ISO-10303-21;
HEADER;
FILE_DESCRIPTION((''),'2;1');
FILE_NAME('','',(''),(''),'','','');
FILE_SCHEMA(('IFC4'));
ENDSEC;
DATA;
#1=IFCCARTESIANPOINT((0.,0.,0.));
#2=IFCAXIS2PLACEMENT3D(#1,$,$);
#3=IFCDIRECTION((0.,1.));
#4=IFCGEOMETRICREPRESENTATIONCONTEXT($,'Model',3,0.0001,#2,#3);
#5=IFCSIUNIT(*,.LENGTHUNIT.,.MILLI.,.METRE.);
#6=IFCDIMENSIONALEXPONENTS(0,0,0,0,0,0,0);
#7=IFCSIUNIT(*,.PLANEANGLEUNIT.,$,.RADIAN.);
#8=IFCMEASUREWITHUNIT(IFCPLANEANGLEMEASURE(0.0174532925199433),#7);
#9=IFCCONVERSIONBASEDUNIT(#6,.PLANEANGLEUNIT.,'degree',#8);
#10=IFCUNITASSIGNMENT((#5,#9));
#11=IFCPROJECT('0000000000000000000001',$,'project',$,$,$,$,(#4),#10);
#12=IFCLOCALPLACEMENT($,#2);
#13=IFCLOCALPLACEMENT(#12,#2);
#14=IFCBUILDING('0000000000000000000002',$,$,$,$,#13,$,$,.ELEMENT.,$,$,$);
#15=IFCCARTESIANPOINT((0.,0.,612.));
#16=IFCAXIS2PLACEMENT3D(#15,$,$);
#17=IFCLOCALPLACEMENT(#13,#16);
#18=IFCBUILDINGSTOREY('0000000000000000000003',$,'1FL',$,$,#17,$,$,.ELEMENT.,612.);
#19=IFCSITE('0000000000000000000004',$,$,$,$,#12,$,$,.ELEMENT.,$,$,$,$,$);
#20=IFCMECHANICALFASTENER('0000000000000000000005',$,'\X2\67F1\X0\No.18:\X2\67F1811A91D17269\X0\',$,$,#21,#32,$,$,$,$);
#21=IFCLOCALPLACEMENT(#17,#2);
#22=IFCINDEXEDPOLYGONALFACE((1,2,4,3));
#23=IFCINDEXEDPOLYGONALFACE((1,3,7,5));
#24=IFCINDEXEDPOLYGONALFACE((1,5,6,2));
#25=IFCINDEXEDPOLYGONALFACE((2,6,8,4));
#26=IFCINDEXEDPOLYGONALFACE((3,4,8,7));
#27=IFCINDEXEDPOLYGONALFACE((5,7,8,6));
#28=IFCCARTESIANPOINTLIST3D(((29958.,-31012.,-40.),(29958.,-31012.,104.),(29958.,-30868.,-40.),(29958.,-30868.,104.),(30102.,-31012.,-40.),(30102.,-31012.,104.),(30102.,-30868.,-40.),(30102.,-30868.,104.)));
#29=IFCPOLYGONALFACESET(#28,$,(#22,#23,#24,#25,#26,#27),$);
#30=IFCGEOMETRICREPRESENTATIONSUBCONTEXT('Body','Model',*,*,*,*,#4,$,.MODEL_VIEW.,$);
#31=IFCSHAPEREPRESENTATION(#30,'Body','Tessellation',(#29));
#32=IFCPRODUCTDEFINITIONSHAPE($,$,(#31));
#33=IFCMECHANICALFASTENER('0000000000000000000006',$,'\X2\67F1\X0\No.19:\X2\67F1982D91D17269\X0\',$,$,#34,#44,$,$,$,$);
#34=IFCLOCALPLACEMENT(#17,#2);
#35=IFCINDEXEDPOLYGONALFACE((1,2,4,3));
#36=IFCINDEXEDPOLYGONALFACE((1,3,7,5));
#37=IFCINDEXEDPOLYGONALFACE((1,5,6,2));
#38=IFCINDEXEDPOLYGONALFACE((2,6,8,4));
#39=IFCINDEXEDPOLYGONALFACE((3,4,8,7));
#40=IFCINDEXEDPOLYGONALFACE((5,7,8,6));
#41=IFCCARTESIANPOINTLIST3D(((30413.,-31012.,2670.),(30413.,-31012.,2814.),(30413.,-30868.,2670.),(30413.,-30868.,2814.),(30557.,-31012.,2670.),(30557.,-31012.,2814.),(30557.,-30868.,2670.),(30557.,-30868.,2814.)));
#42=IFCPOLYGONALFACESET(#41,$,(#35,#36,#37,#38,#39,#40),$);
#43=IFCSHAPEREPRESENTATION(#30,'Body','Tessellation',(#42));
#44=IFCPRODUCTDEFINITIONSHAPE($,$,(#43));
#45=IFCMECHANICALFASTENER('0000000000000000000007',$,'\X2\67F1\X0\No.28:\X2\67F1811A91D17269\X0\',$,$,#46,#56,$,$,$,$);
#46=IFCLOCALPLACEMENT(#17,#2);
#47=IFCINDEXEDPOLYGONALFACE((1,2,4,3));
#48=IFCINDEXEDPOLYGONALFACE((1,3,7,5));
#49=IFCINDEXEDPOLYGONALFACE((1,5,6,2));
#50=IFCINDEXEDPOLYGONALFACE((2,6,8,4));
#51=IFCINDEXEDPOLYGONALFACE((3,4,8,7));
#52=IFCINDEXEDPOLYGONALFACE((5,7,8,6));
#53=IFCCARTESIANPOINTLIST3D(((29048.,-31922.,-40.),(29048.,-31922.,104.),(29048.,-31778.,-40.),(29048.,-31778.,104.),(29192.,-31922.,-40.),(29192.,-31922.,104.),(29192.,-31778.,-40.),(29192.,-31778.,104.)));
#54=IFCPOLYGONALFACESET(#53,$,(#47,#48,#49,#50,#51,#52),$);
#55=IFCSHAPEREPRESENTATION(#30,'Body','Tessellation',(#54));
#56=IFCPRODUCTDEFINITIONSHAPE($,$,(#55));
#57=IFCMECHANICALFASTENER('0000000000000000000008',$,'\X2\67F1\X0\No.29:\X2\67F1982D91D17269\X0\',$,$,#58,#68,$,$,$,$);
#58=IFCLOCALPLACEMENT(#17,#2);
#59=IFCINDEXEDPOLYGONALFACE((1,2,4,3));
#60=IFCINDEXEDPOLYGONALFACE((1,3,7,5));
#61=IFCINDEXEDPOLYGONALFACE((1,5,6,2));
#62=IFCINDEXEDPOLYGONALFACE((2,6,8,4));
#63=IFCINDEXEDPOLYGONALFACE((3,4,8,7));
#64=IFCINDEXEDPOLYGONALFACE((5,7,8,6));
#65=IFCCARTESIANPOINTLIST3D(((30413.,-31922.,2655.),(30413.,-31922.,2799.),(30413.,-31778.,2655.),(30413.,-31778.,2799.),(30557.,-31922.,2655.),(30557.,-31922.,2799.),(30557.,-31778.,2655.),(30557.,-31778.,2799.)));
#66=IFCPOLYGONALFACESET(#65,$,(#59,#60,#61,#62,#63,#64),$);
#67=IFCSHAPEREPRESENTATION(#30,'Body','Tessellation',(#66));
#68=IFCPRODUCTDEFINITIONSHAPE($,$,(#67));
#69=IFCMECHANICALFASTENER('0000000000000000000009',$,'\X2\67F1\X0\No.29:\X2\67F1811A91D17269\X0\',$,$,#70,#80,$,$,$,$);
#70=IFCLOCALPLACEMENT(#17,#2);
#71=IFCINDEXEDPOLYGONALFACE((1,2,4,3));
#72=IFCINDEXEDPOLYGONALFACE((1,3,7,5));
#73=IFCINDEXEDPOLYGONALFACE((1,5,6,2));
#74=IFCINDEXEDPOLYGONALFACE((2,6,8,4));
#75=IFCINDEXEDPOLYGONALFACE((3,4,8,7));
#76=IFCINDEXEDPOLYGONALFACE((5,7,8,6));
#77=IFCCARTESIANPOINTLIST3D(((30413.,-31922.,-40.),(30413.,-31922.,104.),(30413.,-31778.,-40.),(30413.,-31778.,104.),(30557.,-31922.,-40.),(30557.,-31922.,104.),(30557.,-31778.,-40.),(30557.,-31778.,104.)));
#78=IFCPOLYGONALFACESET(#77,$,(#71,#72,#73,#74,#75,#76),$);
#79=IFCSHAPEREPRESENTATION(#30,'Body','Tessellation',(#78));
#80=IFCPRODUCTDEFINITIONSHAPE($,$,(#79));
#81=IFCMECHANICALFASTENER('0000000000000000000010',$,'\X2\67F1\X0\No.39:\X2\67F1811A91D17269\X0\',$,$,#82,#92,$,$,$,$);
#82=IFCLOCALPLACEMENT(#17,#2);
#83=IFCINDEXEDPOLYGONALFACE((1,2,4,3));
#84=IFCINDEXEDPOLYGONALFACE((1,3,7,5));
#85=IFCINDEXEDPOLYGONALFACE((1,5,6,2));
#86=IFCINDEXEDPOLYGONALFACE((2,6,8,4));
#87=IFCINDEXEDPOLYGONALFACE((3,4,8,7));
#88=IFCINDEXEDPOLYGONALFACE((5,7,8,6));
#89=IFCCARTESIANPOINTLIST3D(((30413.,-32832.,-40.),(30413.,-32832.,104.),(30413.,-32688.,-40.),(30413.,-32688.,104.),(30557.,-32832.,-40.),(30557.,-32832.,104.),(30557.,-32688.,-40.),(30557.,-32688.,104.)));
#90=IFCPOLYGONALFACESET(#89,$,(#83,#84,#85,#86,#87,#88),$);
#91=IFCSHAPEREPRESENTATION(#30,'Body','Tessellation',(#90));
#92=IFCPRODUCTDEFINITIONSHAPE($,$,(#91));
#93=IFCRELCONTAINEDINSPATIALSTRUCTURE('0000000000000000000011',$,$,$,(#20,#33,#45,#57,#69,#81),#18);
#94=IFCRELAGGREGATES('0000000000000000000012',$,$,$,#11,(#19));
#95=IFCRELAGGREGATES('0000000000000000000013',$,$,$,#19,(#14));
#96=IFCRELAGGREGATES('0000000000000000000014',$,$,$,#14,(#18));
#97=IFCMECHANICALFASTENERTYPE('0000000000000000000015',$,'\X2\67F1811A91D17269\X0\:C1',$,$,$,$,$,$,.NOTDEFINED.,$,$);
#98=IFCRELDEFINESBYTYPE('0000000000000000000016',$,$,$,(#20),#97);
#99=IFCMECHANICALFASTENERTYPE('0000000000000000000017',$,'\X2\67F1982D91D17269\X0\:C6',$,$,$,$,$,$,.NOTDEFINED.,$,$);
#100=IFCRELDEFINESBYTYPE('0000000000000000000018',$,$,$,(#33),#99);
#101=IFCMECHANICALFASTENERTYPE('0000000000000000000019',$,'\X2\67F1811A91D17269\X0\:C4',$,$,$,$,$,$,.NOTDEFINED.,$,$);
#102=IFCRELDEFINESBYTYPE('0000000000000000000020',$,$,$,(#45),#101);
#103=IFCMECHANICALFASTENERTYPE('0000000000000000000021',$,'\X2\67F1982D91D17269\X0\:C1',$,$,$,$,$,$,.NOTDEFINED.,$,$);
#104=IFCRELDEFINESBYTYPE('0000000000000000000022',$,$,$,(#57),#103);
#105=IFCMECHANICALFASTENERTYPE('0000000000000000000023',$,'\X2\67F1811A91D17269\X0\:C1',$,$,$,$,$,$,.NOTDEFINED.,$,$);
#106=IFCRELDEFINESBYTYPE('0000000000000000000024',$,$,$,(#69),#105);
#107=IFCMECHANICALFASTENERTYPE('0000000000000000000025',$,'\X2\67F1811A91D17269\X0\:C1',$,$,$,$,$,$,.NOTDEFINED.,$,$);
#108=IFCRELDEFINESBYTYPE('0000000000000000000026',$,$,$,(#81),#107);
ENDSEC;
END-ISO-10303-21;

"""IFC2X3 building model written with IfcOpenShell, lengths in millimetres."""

from ifc_helpers import new_model, entity, si_unit, converted_unit, direction, frame, origin, origin_with_axes, origin_2d, place, context, subcontext, project, spatial, rectangle, extrude, type_object, element, save


model = new_model("IFC2X3")

# Units and contexts
model_context = context("Model", 3, precision=0.0001, world=origin(), true_north=direction((0.0, 1.0)))
body_context = subcontext(model_context, "Body", "Model", "MODEL_VIEW")
ifc_project = project(units=[si_unit("LENGTHUNIT", "METRE", prefix="MILLI"), converted_unit("PLANEANGLEUNIT", "degree", entity("IfcPlaneAngleMeasure", 0.0174532925199433), si_unit("PLANEANGLEUNIT", "RADIAN"), dimensions=[0, 0, 0, 0, 0, 0, 0])], contexts=[model_context])

# Site, building, storey
site_placement = place(None, origin())
site = spatial("IfcSite", under=ifc_project, at=site_placement, CompositionType="ELEMENT")
building_placement = place(site_placement, origin())
building = spatial("IfcBuilding", under=site, at=building_placement, CompositionType="ELEMENT")
storey_placement = place(building_placement, frame((0.0, 0.0, 612.0)))
storey = spatial("IfcBuildingStorey", under=building, at=storey_placement, Name="1FL", CompositionType="ELEMENT", Elevation=612.0)

# Mechanical fasteners
mechanical_fastener_type_1 = type_object("IfcMechanicalFastenerType", Name="柱脚金物:C1")
mechanical_fastener_1_placement = place(storey_placement, frame((30030.0, -30940.0, -40.0)))
element("IfcMechanicalFastener", 1, at=mechanical_fastener_1_placement, inside=storey, type_object=mechanical_fastener_type_1, Name="柱No.18:柱脚金物", context=body_context, shape_type="SweptSolid", body=[
    extrude(rectangle(XDim=144.0, YDim=144.0, at=origin_2d()), origin_with_axes(), (0.0, 0.0, 1.0), 144.0),
])
mechanical_fastener_type_2 = type_object("IfcMechanicalFastenerType", Name="柱頭金物:C6")
mechanical_fastener_2_placement = place(storey_placement, frame((30485.0, -30940.0, 2670.0)))
element("IfcMechanicalFastener", 2, at=mechanical_fastener_2_placement, inside=storey, type_object=mechanical_fastener_type_2, Name="柱No.19:柱頭金物", context=body_context, shape_type="SweptSolid", body=[
    extrude(rectangle(XDim=144.0, YDim=144.0, at=origin_2d()), origin_with_axes(), (0.0, 0.0, 1.0), 144.0),
])
mechanical_fastener_type_3 = type_object("IfcMechanicalFastenerType", Name="柱脚金物:C4")
mechanical_fastener_3_placement = place(storey_placement, frame((29120.0, -31850.0, -40.0)))
element("IfcMechanicalFastener", 3, at=mechanical_fastener_3_placement, inside=storey, type_object=mechanical_fastener_type_3, Name="柱No.28:柱脚金物", context=body_context, shape_type="SweptSolid", body=[
    extrude(rectangle(XDim=144.0, YDim=144.0, at=origin_2d()), origin_with_axes(), (0.0, 0.0, 1.0), 144.0),
])
mechanical_fastener_type_4 = type_object("IfcMechanicalFastenerType", Name="柱頭金物:C1")
mechanical_fastener_4_placement = place(storey_placement, frame((30485.0, -31850.0, 2655.0)))
element("IfcMechanicalFastener", 4, at=mechanical_fastener_4_placement, inside=storey, type_object=mechanical_fastener_type_4, Name="柱No.29:柱頭金物", context=body_context, shape_type="SweptSolid", body=[
    extrude(rectangle(XDim=144.0, YDim=144.0, at=origin_2d()), origin_with_axes(), (0.0, 0.0, 1.0), 144.0),
])
mechanical_fastener_type_5 = type_object("IfcMechanicalFastenerType", Name="柱脚金物:C1")
mechanical_fastener_5_placement = place(storey_placement, frame((30485.0, -31850.0, -40.0)))
element("IfcMechanicalFastener", 5, at=mechanical_fastener_5_placement, inside=storey, type_object=mechanical_fastener_type_5, Name="柱No.29:柱脚金物", context=body_context, shape_type="SweptSolid", body=[
    extrude(rectangle(XDim=144.0, YDim=144.0, at=origin_2d()), origin_with_axes(), (0.0, 0.0, 1.0), 144.0),
])
mechanical_fastener_type_6 = type_object("IfcMechanicalFastenerType", Name="柱脚金物:C1")
mechanical_fastener_6_placement = place(storey_placement, frame((30485.0, -32760.0, -40.0)))
element("IfcMechanicalFastener", 6, at=mechanical_fastener_6_placement, inside=storey, type_object=mechanical_fastener_type_6, Name="柱No.39:柱脚金物", context=body_context, shape_type="SweptSolid", body=[
    extrude(rectangle(XDim=144.0, YDim=144.0, at=origin_2d()), origin_with_axes(), (0.0, 0.0, 1.0), 144.0),
])

save(model, "model.ifc")
